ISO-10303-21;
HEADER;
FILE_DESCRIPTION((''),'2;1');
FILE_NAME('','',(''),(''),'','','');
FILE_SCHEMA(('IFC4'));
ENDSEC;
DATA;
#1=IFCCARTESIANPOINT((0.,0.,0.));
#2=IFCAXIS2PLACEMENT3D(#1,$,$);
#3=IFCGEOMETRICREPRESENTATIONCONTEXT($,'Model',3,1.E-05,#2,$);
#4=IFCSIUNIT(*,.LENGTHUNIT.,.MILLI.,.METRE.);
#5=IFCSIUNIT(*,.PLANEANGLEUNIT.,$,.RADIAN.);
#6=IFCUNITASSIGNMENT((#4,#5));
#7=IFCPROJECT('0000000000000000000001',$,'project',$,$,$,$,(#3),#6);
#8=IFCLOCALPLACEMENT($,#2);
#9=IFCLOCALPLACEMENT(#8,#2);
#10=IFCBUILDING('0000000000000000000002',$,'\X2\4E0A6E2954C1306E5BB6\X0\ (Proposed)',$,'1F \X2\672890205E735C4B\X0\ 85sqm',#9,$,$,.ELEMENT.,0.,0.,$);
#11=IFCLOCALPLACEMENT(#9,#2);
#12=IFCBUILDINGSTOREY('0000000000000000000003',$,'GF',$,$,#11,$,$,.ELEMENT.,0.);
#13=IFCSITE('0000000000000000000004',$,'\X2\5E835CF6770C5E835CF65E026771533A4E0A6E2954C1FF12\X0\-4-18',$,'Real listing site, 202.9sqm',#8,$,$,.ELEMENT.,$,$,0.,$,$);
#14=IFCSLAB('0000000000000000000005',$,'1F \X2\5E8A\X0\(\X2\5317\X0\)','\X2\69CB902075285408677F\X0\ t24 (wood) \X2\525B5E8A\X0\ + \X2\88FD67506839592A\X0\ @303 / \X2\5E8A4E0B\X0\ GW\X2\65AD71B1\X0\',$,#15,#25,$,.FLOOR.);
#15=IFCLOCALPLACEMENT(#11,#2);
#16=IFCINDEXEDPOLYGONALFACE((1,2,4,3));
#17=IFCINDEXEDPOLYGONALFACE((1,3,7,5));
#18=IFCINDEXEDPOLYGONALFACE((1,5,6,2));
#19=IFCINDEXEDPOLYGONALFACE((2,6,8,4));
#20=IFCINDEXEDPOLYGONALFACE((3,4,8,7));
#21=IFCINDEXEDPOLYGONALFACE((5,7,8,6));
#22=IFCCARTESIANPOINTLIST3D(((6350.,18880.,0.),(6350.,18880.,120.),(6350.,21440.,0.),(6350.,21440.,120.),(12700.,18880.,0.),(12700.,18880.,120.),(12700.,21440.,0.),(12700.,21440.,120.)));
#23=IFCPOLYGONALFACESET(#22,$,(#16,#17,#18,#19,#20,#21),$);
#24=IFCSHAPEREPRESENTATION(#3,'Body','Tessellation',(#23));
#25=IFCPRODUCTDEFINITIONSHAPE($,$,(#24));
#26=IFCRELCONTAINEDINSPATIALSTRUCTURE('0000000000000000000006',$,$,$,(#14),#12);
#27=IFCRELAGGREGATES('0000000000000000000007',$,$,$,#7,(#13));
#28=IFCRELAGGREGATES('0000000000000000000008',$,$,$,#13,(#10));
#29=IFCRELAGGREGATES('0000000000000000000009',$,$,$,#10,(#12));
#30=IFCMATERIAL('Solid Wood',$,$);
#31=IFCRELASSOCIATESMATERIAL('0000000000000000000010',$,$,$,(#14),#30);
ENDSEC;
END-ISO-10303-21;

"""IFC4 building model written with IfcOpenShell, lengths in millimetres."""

from ifc_helpers import new_model, si_unit, frame, frame_2d, origin, place, context, project, spatial, rectangle, extrude, material, element, save


model = new_model("IFC4")

# Units and contexts
model_context = context("Model", 3, precision=1e-05, world=origin())
ifc_project = project(units=[si_unit("LENGTHUNIT", "METRE", prefix="MILLI"), si_unit("PLANEANGLEUNIT", "RADIAN")], contexts=[model_context])

# Site, building, storey
site_placement = place(None, origin())
site = spatial("IfcSite", under=ifc_project, at=site_placement, Name="広島県広島市東区上温品２-4-18", ObjectType="Real listing site, 202.9sqm", CompositionType="ELEMENT", RefElevation=0.0)
building_placement = place(site_placement, origin())
building = spatial("IfcBuilding", under=site, at=building_placement, Name="上温品の家 (Proposed)", ObjectType="1F 木造平屋 85sqm", CompositionType="ELEMENT", ElevationOfRefHeight=0.0, ElevationOfTerrain=0.0)
storey_placement = place(building_placement, origin())
storey = spatial("IfcBuildingStorey", under=building, at=storey_placement, Name="GF", CompositionType="ELEMENT", Elevation=0.0)

# Slab
ifc_material_1 = material(Name="Solid Wood")
slab_1_placement = place(storey_placement, frame((3175.0, 9440.0, 0.0)))
element("IfcSlab", 1, at=slab_1_placement, inside=storey, material=ifc_material_1, Name="1F 床(北)", Description="構造用合板 t24 (wood) 剛床 + 製材根太 @303 / 床下 GW断熱", PredefinedType="FLOOR", context=model_context, shape_type="SweptSolid", body=[
    extrude(rectangle(XDim=6350.0, YDim=2560.0, at=frame_2d((3175.0, 1280.0))), frame((3175.0, 9440.0, 0.0)), (0.0, 0.0, 1.0), 120.0),
])

save(model, "model.ifc")
